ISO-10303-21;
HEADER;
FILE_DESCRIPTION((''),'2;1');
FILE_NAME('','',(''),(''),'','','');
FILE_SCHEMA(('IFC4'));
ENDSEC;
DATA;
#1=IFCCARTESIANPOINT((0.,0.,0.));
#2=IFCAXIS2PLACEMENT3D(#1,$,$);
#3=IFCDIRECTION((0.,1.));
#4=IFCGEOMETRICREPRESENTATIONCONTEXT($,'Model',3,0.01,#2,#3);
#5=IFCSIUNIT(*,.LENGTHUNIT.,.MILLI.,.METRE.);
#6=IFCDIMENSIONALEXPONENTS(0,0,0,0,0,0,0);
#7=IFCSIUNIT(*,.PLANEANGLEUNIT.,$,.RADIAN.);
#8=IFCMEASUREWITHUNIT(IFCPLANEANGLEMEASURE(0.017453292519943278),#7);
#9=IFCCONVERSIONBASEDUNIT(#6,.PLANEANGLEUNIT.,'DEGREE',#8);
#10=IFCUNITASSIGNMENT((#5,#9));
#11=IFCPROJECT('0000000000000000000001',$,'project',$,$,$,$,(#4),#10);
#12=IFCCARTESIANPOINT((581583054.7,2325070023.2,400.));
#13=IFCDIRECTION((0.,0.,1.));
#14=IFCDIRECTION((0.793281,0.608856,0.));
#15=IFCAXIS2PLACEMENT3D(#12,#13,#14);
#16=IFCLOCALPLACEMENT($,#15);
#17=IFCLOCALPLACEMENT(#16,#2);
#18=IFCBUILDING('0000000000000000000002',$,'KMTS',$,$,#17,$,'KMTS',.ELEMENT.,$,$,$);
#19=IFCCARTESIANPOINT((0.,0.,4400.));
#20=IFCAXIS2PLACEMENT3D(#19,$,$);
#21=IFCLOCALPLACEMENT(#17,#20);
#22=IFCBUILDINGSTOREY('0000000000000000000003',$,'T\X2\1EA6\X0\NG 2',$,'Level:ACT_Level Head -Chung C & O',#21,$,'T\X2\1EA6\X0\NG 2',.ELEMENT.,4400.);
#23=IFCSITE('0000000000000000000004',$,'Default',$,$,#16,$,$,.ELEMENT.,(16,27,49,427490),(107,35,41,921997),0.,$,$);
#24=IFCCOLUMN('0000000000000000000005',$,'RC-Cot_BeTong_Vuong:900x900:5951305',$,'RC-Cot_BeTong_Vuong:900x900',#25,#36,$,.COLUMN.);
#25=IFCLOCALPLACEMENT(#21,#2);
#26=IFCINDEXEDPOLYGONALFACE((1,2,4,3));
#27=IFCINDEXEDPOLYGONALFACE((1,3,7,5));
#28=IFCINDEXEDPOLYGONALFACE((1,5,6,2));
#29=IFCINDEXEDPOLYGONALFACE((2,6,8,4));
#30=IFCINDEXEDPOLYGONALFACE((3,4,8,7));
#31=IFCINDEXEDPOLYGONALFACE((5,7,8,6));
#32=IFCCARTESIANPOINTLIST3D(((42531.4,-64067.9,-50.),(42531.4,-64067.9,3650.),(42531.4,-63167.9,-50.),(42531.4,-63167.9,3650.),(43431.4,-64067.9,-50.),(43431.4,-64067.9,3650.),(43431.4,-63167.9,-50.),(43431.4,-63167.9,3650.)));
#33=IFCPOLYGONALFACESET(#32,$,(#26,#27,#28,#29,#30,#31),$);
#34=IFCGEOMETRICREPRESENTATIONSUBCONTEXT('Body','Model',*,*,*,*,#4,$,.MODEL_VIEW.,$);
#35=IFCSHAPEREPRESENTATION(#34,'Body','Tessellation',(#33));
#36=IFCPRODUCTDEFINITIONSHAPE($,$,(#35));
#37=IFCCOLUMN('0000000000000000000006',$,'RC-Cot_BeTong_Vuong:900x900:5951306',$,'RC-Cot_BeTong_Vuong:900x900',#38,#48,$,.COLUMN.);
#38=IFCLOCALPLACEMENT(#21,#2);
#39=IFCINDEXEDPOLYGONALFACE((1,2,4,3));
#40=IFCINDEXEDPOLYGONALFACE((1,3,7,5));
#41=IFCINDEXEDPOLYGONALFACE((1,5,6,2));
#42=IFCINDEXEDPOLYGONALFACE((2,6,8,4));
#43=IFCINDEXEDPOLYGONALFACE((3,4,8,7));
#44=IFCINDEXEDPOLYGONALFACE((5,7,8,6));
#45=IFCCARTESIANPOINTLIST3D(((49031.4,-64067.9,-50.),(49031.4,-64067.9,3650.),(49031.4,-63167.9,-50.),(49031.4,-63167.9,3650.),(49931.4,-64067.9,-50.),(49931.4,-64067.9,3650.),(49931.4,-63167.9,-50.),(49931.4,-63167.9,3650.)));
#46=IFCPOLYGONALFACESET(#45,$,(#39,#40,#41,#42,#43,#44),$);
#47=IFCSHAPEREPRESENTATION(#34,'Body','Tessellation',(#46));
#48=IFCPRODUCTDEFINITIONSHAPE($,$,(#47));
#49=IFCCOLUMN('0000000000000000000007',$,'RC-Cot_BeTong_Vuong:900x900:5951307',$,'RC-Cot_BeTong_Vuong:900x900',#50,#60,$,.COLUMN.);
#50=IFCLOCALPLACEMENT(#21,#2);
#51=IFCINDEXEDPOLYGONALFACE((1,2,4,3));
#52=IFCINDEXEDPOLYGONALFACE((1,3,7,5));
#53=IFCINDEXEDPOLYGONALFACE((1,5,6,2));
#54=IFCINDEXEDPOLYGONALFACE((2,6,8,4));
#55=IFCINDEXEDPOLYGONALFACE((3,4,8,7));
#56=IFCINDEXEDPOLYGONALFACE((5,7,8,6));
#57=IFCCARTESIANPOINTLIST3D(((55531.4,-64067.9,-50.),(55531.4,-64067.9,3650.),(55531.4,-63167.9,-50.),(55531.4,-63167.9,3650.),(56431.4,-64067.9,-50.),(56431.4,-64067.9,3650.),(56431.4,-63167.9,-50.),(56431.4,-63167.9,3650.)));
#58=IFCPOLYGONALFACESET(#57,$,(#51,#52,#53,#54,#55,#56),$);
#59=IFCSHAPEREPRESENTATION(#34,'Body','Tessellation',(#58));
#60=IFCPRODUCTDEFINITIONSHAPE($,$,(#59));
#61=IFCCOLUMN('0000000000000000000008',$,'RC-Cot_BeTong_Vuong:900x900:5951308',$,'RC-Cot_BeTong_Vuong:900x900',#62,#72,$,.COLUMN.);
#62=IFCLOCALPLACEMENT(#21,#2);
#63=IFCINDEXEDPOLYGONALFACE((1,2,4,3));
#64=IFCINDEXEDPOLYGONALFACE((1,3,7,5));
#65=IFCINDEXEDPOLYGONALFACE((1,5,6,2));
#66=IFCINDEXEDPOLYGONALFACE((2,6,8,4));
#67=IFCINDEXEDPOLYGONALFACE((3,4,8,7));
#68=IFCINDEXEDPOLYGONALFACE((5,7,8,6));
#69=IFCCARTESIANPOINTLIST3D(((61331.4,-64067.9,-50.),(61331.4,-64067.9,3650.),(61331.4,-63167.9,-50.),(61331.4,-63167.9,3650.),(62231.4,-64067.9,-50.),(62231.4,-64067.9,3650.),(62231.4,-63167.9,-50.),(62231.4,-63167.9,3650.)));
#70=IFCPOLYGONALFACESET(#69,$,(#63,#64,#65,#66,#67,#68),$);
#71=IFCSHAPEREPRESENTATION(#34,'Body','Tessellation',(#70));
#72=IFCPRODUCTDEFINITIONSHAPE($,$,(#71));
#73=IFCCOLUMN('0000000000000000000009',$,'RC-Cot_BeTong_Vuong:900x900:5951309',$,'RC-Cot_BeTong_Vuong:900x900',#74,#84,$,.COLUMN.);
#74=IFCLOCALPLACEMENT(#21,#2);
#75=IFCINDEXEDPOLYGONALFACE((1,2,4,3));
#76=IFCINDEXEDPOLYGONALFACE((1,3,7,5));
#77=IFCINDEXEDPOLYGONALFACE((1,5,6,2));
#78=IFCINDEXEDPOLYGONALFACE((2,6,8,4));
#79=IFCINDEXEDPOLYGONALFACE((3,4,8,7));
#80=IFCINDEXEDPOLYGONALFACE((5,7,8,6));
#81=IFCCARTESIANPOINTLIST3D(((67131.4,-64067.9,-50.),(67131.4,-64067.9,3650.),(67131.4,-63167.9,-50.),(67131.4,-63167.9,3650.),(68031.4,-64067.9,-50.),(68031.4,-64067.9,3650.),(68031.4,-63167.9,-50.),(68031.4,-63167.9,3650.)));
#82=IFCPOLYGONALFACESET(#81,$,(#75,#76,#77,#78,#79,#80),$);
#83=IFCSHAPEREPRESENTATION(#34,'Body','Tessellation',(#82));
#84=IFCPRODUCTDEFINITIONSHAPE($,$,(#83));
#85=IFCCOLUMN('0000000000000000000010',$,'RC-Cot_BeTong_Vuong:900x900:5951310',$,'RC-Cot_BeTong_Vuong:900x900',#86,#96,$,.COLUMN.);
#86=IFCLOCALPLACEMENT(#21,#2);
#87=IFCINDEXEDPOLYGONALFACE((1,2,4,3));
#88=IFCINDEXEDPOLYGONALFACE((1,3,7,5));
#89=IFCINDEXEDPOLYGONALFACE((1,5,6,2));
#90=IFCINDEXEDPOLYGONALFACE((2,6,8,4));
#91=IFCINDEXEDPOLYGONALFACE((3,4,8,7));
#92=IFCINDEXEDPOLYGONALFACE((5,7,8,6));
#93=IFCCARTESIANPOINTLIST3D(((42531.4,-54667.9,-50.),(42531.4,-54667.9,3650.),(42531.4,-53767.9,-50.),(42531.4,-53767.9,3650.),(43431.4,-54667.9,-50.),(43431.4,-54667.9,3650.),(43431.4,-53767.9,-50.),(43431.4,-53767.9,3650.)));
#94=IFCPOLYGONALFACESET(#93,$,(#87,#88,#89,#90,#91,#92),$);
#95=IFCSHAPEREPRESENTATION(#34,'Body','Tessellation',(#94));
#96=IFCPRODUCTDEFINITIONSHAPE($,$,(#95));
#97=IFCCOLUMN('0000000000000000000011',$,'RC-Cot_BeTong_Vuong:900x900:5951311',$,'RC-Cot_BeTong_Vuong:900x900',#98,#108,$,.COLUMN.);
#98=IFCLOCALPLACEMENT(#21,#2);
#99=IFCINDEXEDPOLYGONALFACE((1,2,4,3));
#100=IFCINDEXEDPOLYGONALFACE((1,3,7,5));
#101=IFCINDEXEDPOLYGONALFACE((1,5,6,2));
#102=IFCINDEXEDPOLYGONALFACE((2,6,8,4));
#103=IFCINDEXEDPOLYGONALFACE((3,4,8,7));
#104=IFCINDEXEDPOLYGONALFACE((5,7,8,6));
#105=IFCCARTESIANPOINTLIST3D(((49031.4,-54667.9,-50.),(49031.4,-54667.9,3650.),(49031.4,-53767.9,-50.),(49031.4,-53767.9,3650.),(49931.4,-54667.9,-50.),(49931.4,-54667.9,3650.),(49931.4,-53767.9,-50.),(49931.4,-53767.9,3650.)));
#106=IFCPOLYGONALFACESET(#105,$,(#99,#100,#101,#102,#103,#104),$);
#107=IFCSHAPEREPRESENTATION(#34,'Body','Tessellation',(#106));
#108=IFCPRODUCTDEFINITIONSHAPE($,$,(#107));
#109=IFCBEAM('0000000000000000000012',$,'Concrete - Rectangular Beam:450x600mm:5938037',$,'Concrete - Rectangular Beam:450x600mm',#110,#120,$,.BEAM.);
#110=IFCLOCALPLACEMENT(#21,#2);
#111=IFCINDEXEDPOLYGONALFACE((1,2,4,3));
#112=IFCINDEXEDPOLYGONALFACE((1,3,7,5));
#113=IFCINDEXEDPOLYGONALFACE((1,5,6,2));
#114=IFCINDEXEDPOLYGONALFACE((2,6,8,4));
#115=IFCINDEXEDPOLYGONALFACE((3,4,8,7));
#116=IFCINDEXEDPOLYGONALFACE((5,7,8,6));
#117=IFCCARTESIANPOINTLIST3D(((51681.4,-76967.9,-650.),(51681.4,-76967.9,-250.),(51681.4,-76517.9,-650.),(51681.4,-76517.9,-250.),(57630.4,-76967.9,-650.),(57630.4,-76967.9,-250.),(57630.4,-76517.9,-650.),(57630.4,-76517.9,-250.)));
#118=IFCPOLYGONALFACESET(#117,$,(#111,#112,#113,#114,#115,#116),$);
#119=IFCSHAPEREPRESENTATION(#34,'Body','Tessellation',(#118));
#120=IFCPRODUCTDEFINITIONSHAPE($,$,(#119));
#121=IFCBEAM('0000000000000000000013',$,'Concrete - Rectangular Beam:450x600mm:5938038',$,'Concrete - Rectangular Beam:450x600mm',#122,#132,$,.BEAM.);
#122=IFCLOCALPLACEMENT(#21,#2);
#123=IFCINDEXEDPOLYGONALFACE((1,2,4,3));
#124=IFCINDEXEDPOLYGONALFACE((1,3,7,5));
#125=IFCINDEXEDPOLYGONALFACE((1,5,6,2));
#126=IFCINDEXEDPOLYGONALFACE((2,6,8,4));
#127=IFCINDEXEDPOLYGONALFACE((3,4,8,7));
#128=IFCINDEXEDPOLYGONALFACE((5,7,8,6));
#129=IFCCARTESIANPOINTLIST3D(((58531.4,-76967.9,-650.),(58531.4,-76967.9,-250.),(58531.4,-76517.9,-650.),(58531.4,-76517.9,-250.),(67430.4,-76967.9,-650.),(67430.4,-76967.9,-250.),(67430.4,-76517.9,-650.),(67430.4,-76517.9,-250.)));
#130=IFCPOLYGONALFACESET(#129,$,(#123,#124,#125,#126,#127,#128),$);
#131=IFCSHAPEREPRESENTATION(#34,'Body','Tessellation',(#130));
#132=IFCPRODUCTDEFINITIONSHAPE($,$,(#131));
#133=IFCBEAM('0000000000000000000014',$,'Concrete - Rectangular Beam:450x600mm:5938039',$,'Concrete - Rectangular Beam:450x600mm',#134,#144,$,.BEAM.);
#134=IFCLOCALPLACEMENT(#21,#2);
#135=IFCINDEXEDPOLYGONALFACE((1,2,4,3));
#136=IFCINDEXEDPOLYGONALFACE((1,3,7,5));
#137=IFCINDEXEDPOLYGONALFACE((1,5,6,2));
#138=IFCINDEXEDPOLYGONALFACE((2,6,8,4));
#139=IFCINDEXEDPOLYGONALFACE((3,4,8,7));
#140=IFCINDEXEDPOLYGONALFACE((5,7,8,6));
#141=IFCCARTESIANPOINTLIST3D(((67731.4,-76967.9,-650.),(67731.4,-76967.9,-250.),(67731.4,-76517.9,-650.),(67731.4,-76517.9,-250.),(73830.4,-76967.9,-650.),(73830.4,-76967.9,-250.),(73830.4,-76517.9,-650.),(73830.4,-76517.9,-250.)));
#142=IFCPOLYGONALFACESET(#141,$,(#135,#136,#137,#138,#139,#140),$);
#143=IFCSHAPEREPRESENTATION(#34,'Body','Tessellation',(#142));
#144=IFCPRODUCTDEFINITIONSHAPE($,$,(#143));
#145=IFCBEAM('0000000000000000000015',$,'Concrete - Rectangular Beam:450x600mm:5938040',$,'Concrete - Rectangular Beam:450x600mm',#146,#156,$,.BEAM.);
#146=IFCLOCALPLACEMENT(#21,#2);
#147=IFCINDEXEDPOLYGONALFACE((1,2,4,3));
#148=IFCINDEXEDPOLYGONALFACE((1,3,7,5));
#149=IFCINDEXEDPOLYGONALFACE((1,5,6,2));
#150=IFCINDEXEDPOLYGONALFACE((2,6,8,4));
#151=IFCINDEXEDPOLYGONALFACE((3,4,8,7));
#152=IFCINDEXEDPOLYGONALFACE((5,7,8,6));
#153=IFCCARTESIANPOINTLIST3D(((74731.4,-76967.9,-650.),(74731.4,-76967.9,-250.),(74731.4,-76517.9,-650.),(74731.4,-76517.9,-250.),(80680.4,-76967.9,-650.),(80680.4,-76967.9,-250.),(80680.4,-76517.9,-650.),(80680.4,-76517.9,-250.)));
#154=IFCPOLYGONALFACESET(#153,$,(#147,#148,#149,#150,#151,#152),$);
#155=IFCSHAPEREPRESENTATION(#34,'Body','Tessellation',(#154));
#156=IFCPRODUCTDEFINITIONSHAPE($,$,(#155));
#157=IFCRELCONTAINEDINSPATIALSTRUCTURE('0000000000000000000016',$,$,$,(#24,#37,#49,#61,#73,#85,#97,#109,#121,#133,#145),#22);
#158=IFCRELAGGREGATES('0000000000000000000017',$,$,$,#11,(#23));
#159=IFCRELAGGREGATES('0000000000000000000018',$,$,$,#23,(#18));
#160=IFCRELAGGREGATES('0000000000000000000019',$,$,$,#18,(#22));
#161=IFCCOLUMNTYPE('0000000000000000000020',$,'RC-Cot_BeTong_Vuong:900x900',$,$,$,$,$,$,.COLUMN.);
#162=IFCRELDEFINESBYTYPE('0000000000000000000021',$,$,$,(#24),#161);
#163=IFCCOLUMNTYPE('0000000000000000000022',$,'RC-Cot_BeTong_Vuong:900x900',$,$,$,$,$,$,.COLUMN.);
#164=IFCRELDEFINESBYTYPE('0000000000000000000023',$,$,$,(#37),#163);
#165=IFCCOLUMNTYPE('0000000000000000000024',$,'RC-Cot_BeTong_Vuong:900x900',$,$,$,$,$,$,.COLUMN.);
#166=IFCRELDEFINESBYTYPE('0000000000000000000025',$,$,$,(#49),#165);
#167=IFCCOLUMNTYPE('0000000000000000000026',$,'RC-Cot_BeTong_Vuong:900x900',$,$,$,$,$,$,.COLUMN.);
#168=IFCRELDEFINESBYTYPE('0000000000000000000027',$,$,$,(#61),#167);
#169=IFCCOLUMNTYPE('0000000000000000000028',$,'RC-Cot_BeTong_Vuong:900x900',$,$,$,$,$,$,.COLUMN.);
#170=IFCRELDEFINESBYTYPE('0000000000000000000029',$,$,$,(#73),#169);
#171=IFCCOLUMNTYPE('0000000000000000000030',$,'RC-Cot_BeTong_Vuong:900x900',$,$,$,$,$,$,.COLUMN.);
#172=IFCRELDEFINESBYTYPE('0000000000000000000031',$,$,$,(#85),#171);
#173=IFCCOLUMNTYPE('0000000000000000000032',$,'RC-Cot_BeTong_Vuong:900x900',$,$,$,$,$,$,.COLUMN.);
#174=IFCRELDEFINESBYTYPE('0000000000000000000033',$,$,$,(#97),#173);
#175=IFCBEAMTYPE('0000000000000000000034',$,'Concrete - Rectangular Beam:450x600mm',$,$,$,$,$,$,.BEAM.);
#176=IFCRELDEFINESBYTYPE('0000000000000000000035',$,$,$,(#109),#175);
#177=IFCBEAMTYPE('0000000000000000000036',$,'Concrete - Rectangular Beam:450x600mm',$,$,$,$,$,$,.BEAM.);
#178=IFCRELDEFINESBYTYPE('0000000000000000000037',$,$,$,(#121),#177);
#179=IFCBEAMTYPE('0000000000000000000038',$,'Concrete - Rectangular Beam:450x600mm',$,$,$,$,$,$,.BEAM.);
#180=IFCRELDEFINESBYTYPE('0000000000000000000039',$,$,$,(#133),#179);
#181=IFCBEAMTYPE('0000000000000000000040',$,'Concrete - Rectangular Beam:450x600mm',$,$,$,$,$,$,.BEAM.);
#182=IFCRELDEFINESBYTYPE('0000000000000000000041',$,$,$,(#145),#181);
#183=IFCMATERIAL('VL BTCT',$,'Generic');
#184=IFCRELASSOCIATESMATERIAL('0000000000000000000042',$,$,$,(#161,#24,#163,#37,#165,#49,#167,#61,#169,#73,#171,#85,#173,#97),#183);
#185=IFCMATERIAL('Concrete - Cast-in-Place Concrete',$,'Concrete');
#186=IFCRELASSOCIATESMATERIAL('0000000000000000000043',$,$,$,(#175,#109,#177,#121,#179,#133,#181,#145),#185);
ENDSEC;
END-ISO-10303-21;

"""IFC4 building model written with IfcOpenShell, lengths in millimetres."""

from ifc_helpers import new_model, entity, si_unit, converted_unit, direction, frame, origin, place, context, subcontext, project, spatial, indexed_curve, outline, extrude, source, transform, mapped, material, type_object, type_shapes, element, save


model = new_model("IFC4")

# Units and contexts
model_context = context("Model", 3, precision=0.01, world=origin(), true_north=direction((0.0, 1.0)))
body_context = subcontext(model_context, "Body", "Model", "MODEL_VIEW")
ifc_project = project(units=[si_unit("LENGTHUNIT", "METRE", prefix="MILLI"), converted_unit("PLANEANGLEUNIT", "DEGREE", entity("IfcPlaneAngleMeasure", 0.017453292519943278), si_unit("PLANEANGLEUNIT", "RADIAN"), dimensions=[0, 0, 0, 0, 0, 0, 0])], contexts=[model_context])

# Site, building, storey
site_placement = place(None, frame((581583054.7, 2325070023.2, 400.0), z_axis=(0.0, 0.0, 1.0), x_axis=(0.793281, 0.608856, 0.0)))
site = spatial("IfcSite", under=ifc_project, at=site_placement, Name="Default", CompositionType="ELEMENT", RefLatitude=(16, 27, 49, 427490), RefLongitude=(107, 35, 41, 921997), RefElevation=0.0)
building_placement = place(site_placement, origin())
building = spatial("IfcBuilding", under=site, at=building_placement, Name="KMTS", LongName="KMTS", CompositionType="ELEMENT")
storey_placement = place(building_placement, frame((0.0, 0.0, 4400.0)))
storey = spatial("IfcBuildingStorey", under=building, at=storey_placement, Name="TẦNG 2", ObjectType="Level:ACT_Level Head -Chung C & O", LongName="TẦNG 2", CompositionType="ELEMENT", Elevation=4400.0)

# Columns
ifc_material_1 = material(Name="VL BTCT", Category="Generic")
column_type_1 = type_object("IfcColumnType", Name="RC-Cot_BeTong_Vuong:900x900", PredefinedType="COLUMN", material=ifc_material_1)
shared_shape_1 = source(origin(), body_context, "Body", "SweptSolid", [
    extrude(outline(indexed_curve([(-450.0, -450.0), (450.0, -450.0), (450.0, 450.0), (-450.0, 450.0), (-450.0, -450.0)], self_intersect=False)), frame((42981.4, -63617.9, 4350.0), z_axis=(0.0, 0.0, 1.0), x_axis=(-1.0, 0.0, 0.0)), (0.0, 0.0, 1.0), 3700.0),
])
type_shapes(column_type_1, [shared_shape_1])
column_1_placement = place(storey_placement, frame((0.0, 0.0, -4400.0)))
element("IfcColumn", 1, at=column_1_placement, inside=storey, type_object=column_type_1, material=ifc_material_1, Name="RC-Cot_BeTong_Vuong:900x900:5951305", ObjectType="RC-Cot_BeTong_Vuong:900x900", PredefinedType="COLUMN", context=body_context, shape_type="MappedRepresentation", body=[
    mapped(shared_shape_1, transform((0.0, 0.0, 0.0), scale=1.0)),
])
column_type_2 = type_object("IfcColumnType", Name="RC-Cot_BeTong_Vuong:900x900", PredefinedType="COLUMN", material=ifc_material_1)
shared_shape_2 = source(origin(), body_context, "Body", "SweptSolid", [
    extrude(outline(indexed_curve([(-450.0, -450.0), (450.0, -450.0), (450.0, 450.0), (-450.0, 450.0), (-450.0, -450.0)], self_intersect=False)), frame((49481.4, -63617.9, 4350.0), z_axis=(0.0, 0.0, 1.0), x_axis=(-1.0, 0.0, 0.0)), (0.0, 0.0, 1.0), 3700.0),
])
type_shapes(column_type_2, [shared_shape_2])
column_2_placement = place(storey_placement, frame((0.0, 0.0, -4400.0)))
element("IfcColumn", 2, at=column_2_placement, inside=storey, type_object=column_type_2, material=ifc_material_1, Name="RC-Cot_BeTong_Vuong:900x900:5951306", ObjectType="RC-Cot_BeTong_Vuong:900x900", PredefinedType="COLUMN", context=body_context, shape_type="MappedRepresentation", body=[
    mapped(shared_shape_2, transform((0.0, 0.0, 0.0), scale=1.0)),
])
column_type_3 = type_object("IfcColumnType", Name="RC-Cot_BeTong_Vuong:900x900", PredefinedType="COLUMN", material=ifc_material_1)
shared_shape_3 = source(origin(), body_context, "Body", "SweptSolid", [
    extrude(outline(indexed_curve([(-450.0, -450.0), (450.0, -450.0), (450.0, 450.0), (-450.0, 450.0), (-450.0, -450.0)], self_intersect=False)), frame((55981.4, -63617.9, 4350.0), z_axis=(0.0, 0.0, 1.0), x_axis=(-1.0, 0.0, 0.0)), (0.0, 0.0, 1.0), 3700.0),
])
type_shapes(column_type_3, [shared_shape_3])
column_3_placement = place(storey_placement, frame((0.0, 0.0, -4400.0)))
element("IfcColumn", 3, at=column_3_placement, inside=storey, type_object=column_type_3, material=ifc_material_1, Name="RC-Cot_BeTong_Vuong:900x900:5951307", ObjectType="RC-Cot_BeTong_Vuong:900x900", PredefinedType="COLUMN", context=body_context, shape_type="MappedRepresentation", body=[
    mapped(shared_shape_3, transform((0.0, 0.0, 0.0), scale=1.0)),
])
column_type_4 = type_object("IfcColumnType", Name="RC-Cot_BeTong_Vuong:900x900", PredefinedType="COLUMN", material=ifc_material_1)
shared_shape_4 = source(origin(), body_context, "Body", "SweptSolid", [
    extrude(outline(indexed_curve([(-450.0, -450.0), (450.0, -450.0), (450.0, 450.0), (-450.0, 450.0), (-450.0, -450.0)], self_intersect=False)), frame((61781.4, -63617.9, 4350.0), z_axis=(0.0, 0.0, 1.0), x_axis=(-1.0, 0.0, 0.0)), (0.0, 0.0, 1.0), 3700.0),
])
type_shapes(column_type_4, [shared_shape_4])
column_4_placement = place(storey_placement, frame((0.0, 0.0, -4400.0)))
element("IfcColumn", 4, at=column_4_placement, inside=storey, type_object=column_type_4, material=ifc_material_1, Name="RC-Cot_BeTong_Vuong:900x900:5951308", ObjectType="RC-Cot_BeTong_Vuong:900x900", PredefinedType="COLUMN", context=body_context, shape_type="MappedRepresentation", body=[
    mapped(shared_shape_4, transform((0.0, 0.0, 0.0), scale=1.0)),
])
column_type_5 = type_object("IfcColumnType", Name="RC-Cot_BeTong_Vuong:900x900", PredefinedType="COLUMN", material=ifc_material_1)
shared_shape_5 = source(origin(), body_context, "Body", "SweptSolid", [
    extrude(outline(indexed_curve([(-450.0, -450.0), (450.0, -450.0), (450.0, 450.0), (-450.0, 450.0), (-450.0, -450.0)], self_intersect=False)), frame((67581.4, -63617.9, 4350.0), z_axis=(0.0, 0.0, 1.0), x_axis=(-1.0, 0.0, 0.0)), (0.0, 0.0, 1.0), 3700.0),
])
type_shapes(column_type_5, [shared_shape_5])
column_5_placement = place(storey_placement, frame((0.0, 0.0, -4400.0)))
element("IfcColumn", 5, at=column_5_placement, inside=storey, type_object=column_type_5, material=ifc_material_1, Name="RC-Cot_BeTong_Vuong:900x900:5951309", ObjectType="RC-Cot_BeTong_Vuong:900x900", PredefinedType="COLUMN", context=body_context, shape_type="MappedRepresentation", body=[
    mapped(shared_shape_5, transform((0.0, 0.0, 0.0), scale=1.0)),
])
column_type_6 = type_object("IfcColumnType", Name="RC-Cot_BeTong_Vuong:900x900", PredefinedType="COLUMN", material=ifc_material_1)
shared_shape_6 = source(origin(), body_context, "Body", "SweptSolid", [
    extrude(outline(indexed_curve([(-450.0, -450.0), (450.0, -450.0), (450.0, 450.0), (-450.0, 450.0), (-450.0, -450.0)], self_intersect=False)), frame((42981.4, -54217.9, 4350.0), z_axis=(0.0, 0.0, 1.0), x_axis=(-1.0, 0.0, 0.0)), (0.0, 0.0, 1.0), 3700.0),
])
type_shapes(column_type_6, [shared_shape_6])
column_6_placement = place(storey_placement, frame((0.0, 0.0, -4400.0)))
element("IfcColumn", 6, at=column_6_placement, inside=storey, type_object=column_type_6, material=ifc_material_1, Name="RC-Cot_BeTong_Vuong:900x900:5951310", ObjectType="RC-Cot_BeTong_Vuong:900x900", PredefinedType="COLUMN", context=body_context, shape_type="MappedRepresentation", body=[
    mapped(shared_shape_6, transform((0.0, 0.0, 0.0), scale=1.0)),
])
column_type_7 = type_object("IfcColumnType", Name="RC-Cot_BeTong_Vuong:900x900", PredefinedType="COLUMN", material=ifc_material_1)
shared_shape_7 = source(origin(), body_context, "Body", "SweptSolid", [
    extrude(outline(indexed_curve([(-450.0, -450.0), (450.0, -450.0), (450.0, 450.0), (-450.0, 450.0), (-450.0, -450.0)], self_intersect=False)), frame((49481.4, -54217.9, 4350.0), z_axis=(0.0, 0.0, 1.0), x_axis=(-1.0, 0.0, 0.0)), (0.0, 0.0, 1.0), 3700.0),
])
type_shapes(column_type_7, [shared_shape_7])
column_7_placement = place(storey_placement, frame((0.0, 0.0, -4400.0)))
element("IfcColumn", 7, at=column_7_placement, inside=storey, type_object=column_type_7, material=ifc_material_1, Name="RC-Cot_BeTong_Vuong:900x900:5951311", ObjectType="RC-Cot_BeTong_Vuong:900x900", PredefinedType="COLUMN", context=body_context, shape_type="MappedRepresentation", body=[
    mapped(shared_shape_7, transform((0.0, 0.0, 0.0), scale=1.0)),
])

# Beams
ifc_material_2 = material(Name="Concrete - Cast-in-Place Concrete", Category="Concrete")
beam_type_1 = type_object("IfcBeamType", Name="Concrete - Rectangular Beam:450x600mm", PredefinedType="BEAM", material=ifc_material_2)
shared_shape_8 = source(origin(), body_context, "Body", "SweptSolid", [
    extrude(outline(indexed_curve([(-200.0, -225.0), (200.0, -225.0), (200.0, 225.0), (-200.0, 225.0), (-200.0, -225.0)], self_intersect=False)), frame((51681.4, -76742.9, 3950.0), z_axis=(1.0, 0.0, 0.0), x_axis=(0.0, 0.0, -1.0)), (0.0, 0.0, 1.0), 5949.0),
])
type_shapes(beam_type_1, [shared_shape_8])
beam_1_placement = place(storey_placement, frame((0.0, 0.0, -4400.0)))
element("IfcBeam", 8, at=beam_1_placement, inside=storey, type_object=beam_type_1, material=ifc_material_2, Name="Concrete - Rectangular Beam:450x600mm:5938037", ObjectType="Concrete - Rectangular Beam:450x600mm", PredefinedType="BEAM", context=body_context, shape_type="MappedRepresentation", body=[
    mapped(shared_shape_8, transform((0.0, 0.0, 0.0), scale=1.0)),
])
beam_type_2 = type_object("IfcBeamType", Name="Concrete - Rectangular Beam:450x600mm", PredefinedType="BEAM", material=ifc_material_2)
shared_shape_9 = source(origin(), body_context, "Body", "SweptSolid", [
    extrude(outline(indexed_curve([(-200.0, -225.0), (200.0, -225.0), (200.0, 225.0), (-200.0, 225.0), (-200.0, -225.0)], self_intersect=False)), frame((67430.4, -76742.9, 3950.0), z_axis=(-1.0, 0.0, 0.0), x_axis=(0.0, 0.0, -1.0)), (0.0, 0.0, 1.0), 8899.0),
])
type_shapes(beam_type_2, [shared_shape_9])
beam_2_placement = place(storey_placement, frame((0.0, 0.0, -4400.0)))
element("IfcBeam", 9, at=beam_2_placement, inside=storey, type_object=beam_type_2, material=ifc_material_2, Name="Concrete - Rectangular Beam:450x600mm:5938038", ObjectType="Concrete - Rectangular Beam:450x600mm", PredefinedType="BEAM", context=body_context, shape_type="MappedRepresentation", body=[
    mapped(shared_shape_9, transform((0.0, 0.0, 0.0), scale=1.0)),
])
beam_type_3 = type_object("IfcBeamType", Name="Concrete - Rectangular Beam:450x600mm", PredefinedType="BEAM", material=ifc_material_2)
shared_shape_10 = source(origin(), body_context, "Body", "SweptSolid", [
    extrude(outline(indexed_curve([(-200.0, -225.0), (200.0, -225.0), (200.0, 225.0), (-200.0, 225.0), (-200.0, -225.0)], self_intersect=False)), frame((67731.4, -76742.9, 3950.0), z_axis=(1.0, 0.0, 0.0), x_axis=(0.0, 0.0, -1.0)), (0.0, 0.0, 1.0), 6099.0),
])
type_shapes(beam_type_3, [shared_shape_10])
beam_3_placement = place(storey_placement, frame((0.0, 0.0, -4400.0)))
element("IfcBeam", 10, at=beam_3_placement, inside=storey, type_object=beam_type_3, material=ifc_material_2, Name="Concrete - Rectangular Beam:450x600mm:5938039", ObjectType="Concrete - Rectangular Beam:450x600mm", PredefinedType="BEAM", context=body_context, shape_type="MappedRepresentation", body=[
    mapped(shared_shape_10, transform((0.0, 0.0, 0.0), scale=1.0)),
])
beam_type_4 = type_object("IfcBeamType", Name="Concrete - Rectangular Beam:450x600mm", PredefinedType="BEAM", material=ifc_material_2)
shared_shape_11 = source(origin(), body_context, "Body", "SweptSolid", [
    extrude(outline(indexed_curve([(-200.0, -225.0), (200.0, -225.0), (200.0, 225.0), (-200.0, 225.0), (-200.0, -225.0)], self_intersect=False)), frame((74731.4, -76742.9, 3950.0), z_axis=(1.0, 0.0, 0.0), x_axis=(0.0, 0.0, -1.0)), (0.0, 0.0, 1.0), 5949.0),
])
type_shapes(beam_type_4, [shared_shape_11])
beam_4_placement = place(storey_placement, frame((0.0, 0.0, -4400.0)))
element("IfcBeam", 11, at=beam_4_placement, inside=storey, type_object=beam_type_4, material=ifc_material_2, Name="Concrete - Rectangular Beam:450x600mm:5938040", ObjectType="Concrete - Rectangular Beam:450x600mm", PredefinedType="BEAM", context=body_context, shape_type="MappedRepresentation", body=[
    mapped(shared_shape_11, transform((0.0, 0.0, 0.0), scale=1.0)),
])

save(model, "model.ifc")
